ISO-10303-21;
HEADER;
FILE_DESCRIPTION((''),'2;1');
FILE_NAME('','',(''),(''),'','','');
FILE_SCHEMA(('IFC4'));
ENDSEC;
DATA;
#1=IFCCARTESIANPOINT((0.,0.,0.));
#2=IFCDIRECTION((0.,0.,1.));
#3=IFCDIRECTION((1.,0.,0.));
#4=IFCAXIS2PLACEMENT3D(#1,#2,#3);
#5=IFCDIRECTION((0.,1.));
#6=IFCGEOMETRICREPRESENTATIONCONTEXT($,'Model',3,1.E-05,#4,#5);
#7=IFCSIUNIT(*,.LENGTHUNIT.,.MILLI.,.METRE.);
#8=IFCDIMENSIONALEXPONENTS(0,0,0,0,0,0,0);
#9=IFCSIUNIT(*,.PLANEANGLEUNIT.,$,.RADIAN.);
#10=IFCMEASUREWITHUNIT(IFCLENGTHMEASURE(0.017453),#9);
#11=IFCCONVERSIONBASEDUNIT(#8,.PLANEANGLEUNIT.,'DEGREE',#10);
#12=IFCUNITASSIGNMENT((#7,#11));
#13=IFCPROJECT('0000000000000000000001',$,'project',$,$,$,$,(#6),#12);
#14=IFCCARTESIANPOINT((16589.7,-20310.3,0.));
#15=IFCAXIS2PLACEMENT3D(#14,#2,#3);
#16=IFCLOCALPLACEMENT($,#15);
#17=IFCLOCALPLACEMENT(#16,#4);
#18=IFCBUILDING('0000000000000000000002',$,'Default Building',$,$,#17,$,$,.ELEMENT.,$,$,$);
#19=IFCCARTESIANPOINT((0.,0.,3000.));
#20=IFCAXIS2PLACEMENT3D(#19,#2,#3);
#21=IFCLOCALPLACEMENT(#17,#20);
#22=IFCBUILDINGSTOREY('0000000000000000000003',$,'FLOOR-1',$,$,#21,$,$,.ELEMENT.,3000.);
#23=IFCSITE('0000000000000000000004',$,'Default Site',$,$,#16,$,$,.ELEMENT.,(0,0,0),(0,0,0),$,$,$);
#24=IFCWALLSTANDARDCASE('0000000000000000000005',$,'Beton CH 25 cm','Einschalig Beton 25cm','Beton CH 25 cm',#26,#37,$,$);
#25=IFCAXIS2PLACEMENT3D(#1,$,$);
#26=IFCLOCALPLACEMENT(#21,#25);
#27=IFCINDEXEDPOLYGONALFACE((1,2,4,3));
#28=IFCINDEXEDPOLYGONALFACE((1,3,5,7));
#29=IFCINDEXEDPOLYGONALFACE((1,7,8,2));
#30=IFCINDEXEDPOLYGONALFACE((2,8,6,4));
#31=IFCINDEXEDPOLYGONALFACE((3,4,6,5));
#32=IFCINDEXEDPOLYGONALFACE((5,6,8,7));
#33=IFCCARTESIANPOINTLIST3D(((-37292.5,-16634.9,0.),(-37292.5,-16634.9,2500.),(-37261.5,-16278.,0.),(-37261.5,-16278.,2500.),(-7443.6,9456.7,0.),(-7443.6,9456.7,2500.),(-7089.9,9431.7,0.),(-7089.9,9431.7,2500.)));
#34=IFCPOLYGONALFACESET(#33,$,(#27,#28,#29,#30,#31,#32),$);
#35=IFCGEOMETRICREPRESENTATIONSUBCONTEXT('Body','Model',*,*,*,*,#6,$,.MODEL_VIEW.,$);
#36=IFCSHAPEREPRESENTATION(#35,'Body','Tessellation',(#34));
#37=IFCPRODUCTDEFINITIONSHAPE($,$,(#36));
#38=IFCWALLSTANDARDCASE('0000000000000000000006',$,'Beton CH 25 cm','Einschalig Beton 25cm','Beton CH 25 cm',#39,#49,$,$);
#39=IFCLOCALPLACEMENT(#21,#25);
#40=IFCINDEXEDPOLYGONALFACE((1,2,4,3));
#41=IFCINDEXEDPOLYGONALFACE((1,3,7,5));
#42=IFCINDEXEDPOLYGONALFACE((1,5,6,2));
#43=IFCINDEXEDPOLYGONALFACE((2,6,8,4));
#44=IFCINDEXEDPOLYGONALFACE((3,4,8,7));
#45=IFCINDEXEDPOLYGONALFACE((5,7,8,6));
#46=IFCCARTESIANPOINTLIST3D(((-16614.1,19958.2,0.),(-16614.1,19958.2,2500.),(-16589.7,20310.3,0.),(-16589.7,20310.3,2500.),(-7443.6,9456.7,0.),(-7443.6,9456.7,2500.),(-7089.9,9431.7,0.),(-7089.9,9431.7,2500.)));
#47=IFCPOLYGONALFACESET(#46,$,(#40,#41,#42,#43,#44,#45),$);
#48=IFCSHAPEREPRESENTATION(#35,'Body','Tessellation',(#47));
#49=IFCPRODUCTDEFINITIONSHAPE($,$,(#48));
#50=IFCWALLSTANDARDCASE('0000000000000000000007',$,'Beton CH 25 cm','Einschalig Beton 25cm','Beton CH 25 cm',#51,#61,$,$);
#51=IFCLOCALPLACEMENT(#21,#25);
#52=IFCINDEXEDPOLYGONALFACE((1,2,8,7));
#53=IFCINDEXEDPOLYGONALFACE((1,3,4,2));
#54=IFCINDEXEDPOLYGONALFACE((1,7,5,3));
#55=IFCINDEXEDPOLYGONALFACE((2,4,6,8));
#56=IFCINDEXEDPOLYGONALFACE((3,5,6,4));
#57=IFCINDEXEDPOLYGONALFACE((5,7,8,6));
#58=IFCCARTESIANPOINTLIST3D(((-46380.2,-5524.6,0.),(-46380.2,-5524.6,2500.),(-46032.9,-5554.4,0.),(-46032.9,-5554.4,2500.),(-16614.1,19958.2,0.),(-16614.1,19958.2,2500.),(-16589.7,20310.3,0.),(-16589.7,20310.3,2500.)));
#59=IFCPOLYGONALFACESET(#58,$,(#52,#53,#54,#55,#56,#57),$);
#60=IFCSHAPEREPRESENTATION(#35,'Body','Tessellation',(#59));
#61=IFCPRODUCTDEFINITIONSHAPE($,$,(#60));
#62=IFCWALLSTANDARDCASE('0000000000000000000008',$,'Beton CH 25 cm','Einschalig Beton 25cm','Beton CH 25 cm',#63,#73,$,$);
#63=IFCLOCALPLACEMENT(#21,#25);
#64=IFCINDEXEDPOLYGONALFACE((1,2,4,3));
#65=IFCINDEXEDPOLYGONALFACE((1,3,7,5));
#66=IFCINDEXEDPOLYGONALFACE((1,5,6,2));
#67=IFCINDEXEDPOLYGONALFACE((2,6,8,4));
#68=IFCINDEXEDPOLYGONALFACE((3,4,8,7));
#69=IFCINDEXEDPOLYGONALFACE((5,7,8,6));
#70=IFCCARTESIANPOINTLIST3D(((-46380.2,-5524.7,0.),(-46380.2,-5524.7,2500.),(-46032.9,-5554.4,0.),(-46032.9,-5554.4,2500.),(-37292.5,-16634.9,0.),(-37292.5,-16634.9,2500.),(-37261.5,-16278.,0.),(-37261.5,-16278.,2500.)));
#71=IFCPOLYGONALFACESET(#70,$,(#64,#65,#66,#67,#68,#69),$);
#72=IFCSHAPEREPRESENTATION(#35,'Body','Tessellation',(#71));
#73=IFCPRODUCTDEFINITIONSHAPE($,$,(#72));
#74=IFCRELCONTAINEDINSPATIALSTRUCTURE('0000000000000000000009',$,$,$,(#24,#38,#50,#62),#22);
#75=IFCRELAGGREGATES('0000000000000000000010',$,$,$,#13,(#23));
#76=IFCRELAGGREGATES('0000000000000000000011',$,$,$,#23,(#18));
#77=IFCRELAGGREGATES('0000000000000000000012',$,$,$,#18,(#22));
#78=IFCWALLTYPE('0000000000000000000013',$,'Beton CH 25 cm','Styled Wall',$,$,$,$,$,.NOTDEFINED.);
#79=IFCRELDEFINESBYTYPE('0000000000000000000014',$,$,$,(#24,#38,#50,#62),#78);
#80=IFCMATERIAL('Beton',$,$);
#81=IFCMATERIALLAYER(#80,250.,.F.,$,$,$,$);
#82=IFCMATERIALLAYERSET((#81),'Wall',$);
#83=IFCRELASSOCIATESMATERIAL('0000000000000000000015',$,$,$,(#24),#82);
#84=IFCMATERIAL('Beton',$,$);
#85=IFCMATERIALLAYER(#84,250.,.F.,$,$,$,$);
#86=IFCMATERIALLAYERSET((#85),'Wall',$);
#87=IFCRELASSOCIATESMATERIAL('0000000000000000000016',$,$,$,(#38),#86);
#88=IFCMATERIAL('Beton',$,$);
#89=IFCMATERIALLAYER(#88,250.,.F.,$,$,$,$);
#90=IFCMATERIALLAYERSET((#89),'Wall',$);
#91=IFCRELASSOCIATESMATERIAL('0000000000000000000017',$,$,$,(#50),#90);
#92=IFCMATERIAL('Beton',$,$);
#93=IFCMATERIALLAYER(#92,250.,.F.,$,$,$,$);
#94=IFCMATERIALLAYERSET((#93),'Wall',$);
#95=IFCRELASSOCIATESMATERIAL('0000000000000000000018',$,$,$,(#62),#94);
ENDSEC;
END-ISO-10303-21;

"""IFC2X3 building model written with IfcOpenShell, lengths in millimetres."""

from ifc_helpers import new_model, entity, si_unit, converted_unit, direction, frame, origin_with_axes, place, context, subcontext, project, spatial, polyline, outline, extrude, material, layer, layer_set, layer_usage, type_object, element, save


model = new_model("IFC2X3")

# Units and contexts
model_context = context("Model", 3, precision=1e-05, world=origin_with_axes(), true_north=direction((0.0, 1.0)))
body_context = subcontext(model_context, "Body", "Model", "MODEL_VIEW")
ifc_project = project(units=[si_unit("LENGTHUNIT", "METRE", prefix="MILLI"), converted_unit("PLANEANGLEUNIT", "DEGREE", entity("IfcLengthMeasure", 0.017453), si_unit("PLANEANGLEUNIT", "RADIAN"), dimensions=[0, 0, 0, 0, 0, 0, 0])], contexts=[model_context])

# Site, building, storey
site_placement = place(None, frame((16589.7, -20310.3, 0.0), z_axis=(0.0, 0.0, 1.0), x_axis=(1.0, 0.0, 0.0)))
site = spatial("IfcSite", under=ifc_project, at=site_placement, Name="Default Site", CompositionType="ELEMENT", RefLatitude=(0, 0, 0), RefLongitude=(0, 0, 0))
building_placement = place(site_placement, origin_with_axes())
building = spatial("IfcBuilding", under=site, at=building_placement, Name="Default Building", CompositionType="ELEMENT")
storey_placement = place(building_placement, frame((0.0, 0.0, 3000.0), z_axis=(0.0, 0.0, 1.0), x_axis=(1.0, 0.0, 0.0)))
storey = spatial("IfcBuildingStorey", under=building, at=storey_placement, Name="FLOOR-1", CompositionType="ELEMENT", Elevation=3000.0)

# Walls
ifc_material_1 = material(Name="Beton")
ifc_layer_1 = layer(ifc_material_1, 250.0, ventilated=False)
ifc_layer_set_1 = layer_set([ifc_layer_1], Name="Wall")
ifc_layer_usage_1 = layer_usage(ifc_layer_set_1, "AXIS2", "POSITIVE", -125.0)
wall_type = type_object("IfcWallType", Name="Beton CH 25 cm", Description="Styled Wall", PredefinedType="NOTDEFINED")
wall_1_placement = place(storey_placement, frame((-37277.0, -16456.5, 0.0), z_axis=(0.0, 0.0, 1.0), x_axis=(0.757039, 0.65337, 0.0)))
element("IfcWallStandardCase", 1, at=wall_1_placement, inside=storey, type_object=wall_type, material=ifc_layer_usage_1, Name="Beton CH 25 cm", Description="Einschalig Beton 25cm", ObjectType="Beton CH 25 cm", context=body_context, shape_type="SweptSolid", body=[
    extrude(outline(polyline([(39767.3, -125.0), (39515.9, 125.0), (128.3, 125.0), (-128.3, -125.0), (39767.3, -125.0)])), origin_with_axes(), (0.0, 0.0, 1.0), 2500.0),
])
ifc_material_2 = material(Name="Beton")
ifc_layer_2 = layer(ifc_material_2, 250.0, ventilated=False)
ifc_layer_set_2 = layer_set([ifc_layer_2], Name="Wall")
ifc_layer_usage_2 = layer_usage(ifc_layer_set_2, "AXIS2", "POSITIVE", -125.0)
wall_2_placement = place(storey_placement, frame((-7266.8, 9444.2, 0.0), z_axis=(0.0, 0.0, 1.0), x_axis=(-0.657756, 0.753231, 0.0)))
element("IfcWallStandardCase", 2, at=wall_2_placement, inside=storey, type_object=wall_type, material=ifc_layer_usage_2, Name="Beton CH 25 cm", Description="Einschalig Beton 25cm", ObjectType="Beton CH 25 cm", context=body_context, shape_type="SweptSolid", body=[
    extrude(outline(polyline([(14316.9, -125.0), (14067.8, 125.0), (125.7, 125.0), (-125.7, -125.0), (14316.9, -125.0)])), origin_with_axes(), (0.0, 0.0, 1.0), 2500.0),
])
ifc_material_3 = material(Name="Beton")
ifc_layer_3 = layer(ifc_material_3, 250.0, ventilated=False)
ifc_layer_set_3 = layer_set([ifc_layer_3], Name="Wall")
ifc_layer_usage_3 = layer_usage(ifc_layer_set_3, "AXIS2", "POSITIVE", -125.0)
wall_3_placement = place(storey_placement, frame((-16601.9, 20134.3, 0.0), z_axis=(0.0, 0.0, 1.0), x_axis=(-0.755481, -0.65517, 0.0)))
element("IfcWallStandardCase", 3, at=wall_3_placement, inside=storey, type_object=wall_type, material=ifc_layer_usage_3, Name="Beton CH 25 cm", Description="Einschalig Beton 25cm", ObjectType="Beton CH 25 cm", context=body_context, shape_type="SweptSolid", body=[
    extrude(outline(polyline([(39307.9, -125.0), (39065.0, 125.0), (124.6, 125.0), (-124.6, -125.0), (39307.9, -125.0)])), origin_with_axes(), (0.0, 0.0, 1.0), 2500.0),
])
ifc_material_4 = material(Name="Beton")
ifc_layer_4 = layer(ifc_material_4, 250.0, ventilated=False)
ifc_layer_set_4 = layer_set([ifc_layer_4], Name="Wall")
ifc_layer_usage_4 = layer_usage(ifc_layer_set_4, "AXIS2", "POSITIVE", -125.0)
wall_4_placement = place(storey_placement, frame((-46206.5, -5539.5, 0.0), z_axis=(0.0, 0.0, 1.0), x_axis=(0.633131, -0.774045, 0.0)))
element("IfcWallStandardCase", 4, at=wall_4_placement, inside=storey, type_object=wall_type, material=ifc_layer_usage_4, Name="Beton CH 25 cm", Description="Einschalig Beton 25cm", ObjectType="Beton CH 25 cm", context=body_context, shape_type="SweptSolid", body=[
    extrude(outline(polyline([(14232.1, -125.0), (13975.4, 125.0), (121.4, 125.0), (-121.4, -125.0), (14232.1, -125.0)])), origin_with_axes(), (0.0, 0.0, 1.0), 2500.0),
])

save(model, "model.ifc")
